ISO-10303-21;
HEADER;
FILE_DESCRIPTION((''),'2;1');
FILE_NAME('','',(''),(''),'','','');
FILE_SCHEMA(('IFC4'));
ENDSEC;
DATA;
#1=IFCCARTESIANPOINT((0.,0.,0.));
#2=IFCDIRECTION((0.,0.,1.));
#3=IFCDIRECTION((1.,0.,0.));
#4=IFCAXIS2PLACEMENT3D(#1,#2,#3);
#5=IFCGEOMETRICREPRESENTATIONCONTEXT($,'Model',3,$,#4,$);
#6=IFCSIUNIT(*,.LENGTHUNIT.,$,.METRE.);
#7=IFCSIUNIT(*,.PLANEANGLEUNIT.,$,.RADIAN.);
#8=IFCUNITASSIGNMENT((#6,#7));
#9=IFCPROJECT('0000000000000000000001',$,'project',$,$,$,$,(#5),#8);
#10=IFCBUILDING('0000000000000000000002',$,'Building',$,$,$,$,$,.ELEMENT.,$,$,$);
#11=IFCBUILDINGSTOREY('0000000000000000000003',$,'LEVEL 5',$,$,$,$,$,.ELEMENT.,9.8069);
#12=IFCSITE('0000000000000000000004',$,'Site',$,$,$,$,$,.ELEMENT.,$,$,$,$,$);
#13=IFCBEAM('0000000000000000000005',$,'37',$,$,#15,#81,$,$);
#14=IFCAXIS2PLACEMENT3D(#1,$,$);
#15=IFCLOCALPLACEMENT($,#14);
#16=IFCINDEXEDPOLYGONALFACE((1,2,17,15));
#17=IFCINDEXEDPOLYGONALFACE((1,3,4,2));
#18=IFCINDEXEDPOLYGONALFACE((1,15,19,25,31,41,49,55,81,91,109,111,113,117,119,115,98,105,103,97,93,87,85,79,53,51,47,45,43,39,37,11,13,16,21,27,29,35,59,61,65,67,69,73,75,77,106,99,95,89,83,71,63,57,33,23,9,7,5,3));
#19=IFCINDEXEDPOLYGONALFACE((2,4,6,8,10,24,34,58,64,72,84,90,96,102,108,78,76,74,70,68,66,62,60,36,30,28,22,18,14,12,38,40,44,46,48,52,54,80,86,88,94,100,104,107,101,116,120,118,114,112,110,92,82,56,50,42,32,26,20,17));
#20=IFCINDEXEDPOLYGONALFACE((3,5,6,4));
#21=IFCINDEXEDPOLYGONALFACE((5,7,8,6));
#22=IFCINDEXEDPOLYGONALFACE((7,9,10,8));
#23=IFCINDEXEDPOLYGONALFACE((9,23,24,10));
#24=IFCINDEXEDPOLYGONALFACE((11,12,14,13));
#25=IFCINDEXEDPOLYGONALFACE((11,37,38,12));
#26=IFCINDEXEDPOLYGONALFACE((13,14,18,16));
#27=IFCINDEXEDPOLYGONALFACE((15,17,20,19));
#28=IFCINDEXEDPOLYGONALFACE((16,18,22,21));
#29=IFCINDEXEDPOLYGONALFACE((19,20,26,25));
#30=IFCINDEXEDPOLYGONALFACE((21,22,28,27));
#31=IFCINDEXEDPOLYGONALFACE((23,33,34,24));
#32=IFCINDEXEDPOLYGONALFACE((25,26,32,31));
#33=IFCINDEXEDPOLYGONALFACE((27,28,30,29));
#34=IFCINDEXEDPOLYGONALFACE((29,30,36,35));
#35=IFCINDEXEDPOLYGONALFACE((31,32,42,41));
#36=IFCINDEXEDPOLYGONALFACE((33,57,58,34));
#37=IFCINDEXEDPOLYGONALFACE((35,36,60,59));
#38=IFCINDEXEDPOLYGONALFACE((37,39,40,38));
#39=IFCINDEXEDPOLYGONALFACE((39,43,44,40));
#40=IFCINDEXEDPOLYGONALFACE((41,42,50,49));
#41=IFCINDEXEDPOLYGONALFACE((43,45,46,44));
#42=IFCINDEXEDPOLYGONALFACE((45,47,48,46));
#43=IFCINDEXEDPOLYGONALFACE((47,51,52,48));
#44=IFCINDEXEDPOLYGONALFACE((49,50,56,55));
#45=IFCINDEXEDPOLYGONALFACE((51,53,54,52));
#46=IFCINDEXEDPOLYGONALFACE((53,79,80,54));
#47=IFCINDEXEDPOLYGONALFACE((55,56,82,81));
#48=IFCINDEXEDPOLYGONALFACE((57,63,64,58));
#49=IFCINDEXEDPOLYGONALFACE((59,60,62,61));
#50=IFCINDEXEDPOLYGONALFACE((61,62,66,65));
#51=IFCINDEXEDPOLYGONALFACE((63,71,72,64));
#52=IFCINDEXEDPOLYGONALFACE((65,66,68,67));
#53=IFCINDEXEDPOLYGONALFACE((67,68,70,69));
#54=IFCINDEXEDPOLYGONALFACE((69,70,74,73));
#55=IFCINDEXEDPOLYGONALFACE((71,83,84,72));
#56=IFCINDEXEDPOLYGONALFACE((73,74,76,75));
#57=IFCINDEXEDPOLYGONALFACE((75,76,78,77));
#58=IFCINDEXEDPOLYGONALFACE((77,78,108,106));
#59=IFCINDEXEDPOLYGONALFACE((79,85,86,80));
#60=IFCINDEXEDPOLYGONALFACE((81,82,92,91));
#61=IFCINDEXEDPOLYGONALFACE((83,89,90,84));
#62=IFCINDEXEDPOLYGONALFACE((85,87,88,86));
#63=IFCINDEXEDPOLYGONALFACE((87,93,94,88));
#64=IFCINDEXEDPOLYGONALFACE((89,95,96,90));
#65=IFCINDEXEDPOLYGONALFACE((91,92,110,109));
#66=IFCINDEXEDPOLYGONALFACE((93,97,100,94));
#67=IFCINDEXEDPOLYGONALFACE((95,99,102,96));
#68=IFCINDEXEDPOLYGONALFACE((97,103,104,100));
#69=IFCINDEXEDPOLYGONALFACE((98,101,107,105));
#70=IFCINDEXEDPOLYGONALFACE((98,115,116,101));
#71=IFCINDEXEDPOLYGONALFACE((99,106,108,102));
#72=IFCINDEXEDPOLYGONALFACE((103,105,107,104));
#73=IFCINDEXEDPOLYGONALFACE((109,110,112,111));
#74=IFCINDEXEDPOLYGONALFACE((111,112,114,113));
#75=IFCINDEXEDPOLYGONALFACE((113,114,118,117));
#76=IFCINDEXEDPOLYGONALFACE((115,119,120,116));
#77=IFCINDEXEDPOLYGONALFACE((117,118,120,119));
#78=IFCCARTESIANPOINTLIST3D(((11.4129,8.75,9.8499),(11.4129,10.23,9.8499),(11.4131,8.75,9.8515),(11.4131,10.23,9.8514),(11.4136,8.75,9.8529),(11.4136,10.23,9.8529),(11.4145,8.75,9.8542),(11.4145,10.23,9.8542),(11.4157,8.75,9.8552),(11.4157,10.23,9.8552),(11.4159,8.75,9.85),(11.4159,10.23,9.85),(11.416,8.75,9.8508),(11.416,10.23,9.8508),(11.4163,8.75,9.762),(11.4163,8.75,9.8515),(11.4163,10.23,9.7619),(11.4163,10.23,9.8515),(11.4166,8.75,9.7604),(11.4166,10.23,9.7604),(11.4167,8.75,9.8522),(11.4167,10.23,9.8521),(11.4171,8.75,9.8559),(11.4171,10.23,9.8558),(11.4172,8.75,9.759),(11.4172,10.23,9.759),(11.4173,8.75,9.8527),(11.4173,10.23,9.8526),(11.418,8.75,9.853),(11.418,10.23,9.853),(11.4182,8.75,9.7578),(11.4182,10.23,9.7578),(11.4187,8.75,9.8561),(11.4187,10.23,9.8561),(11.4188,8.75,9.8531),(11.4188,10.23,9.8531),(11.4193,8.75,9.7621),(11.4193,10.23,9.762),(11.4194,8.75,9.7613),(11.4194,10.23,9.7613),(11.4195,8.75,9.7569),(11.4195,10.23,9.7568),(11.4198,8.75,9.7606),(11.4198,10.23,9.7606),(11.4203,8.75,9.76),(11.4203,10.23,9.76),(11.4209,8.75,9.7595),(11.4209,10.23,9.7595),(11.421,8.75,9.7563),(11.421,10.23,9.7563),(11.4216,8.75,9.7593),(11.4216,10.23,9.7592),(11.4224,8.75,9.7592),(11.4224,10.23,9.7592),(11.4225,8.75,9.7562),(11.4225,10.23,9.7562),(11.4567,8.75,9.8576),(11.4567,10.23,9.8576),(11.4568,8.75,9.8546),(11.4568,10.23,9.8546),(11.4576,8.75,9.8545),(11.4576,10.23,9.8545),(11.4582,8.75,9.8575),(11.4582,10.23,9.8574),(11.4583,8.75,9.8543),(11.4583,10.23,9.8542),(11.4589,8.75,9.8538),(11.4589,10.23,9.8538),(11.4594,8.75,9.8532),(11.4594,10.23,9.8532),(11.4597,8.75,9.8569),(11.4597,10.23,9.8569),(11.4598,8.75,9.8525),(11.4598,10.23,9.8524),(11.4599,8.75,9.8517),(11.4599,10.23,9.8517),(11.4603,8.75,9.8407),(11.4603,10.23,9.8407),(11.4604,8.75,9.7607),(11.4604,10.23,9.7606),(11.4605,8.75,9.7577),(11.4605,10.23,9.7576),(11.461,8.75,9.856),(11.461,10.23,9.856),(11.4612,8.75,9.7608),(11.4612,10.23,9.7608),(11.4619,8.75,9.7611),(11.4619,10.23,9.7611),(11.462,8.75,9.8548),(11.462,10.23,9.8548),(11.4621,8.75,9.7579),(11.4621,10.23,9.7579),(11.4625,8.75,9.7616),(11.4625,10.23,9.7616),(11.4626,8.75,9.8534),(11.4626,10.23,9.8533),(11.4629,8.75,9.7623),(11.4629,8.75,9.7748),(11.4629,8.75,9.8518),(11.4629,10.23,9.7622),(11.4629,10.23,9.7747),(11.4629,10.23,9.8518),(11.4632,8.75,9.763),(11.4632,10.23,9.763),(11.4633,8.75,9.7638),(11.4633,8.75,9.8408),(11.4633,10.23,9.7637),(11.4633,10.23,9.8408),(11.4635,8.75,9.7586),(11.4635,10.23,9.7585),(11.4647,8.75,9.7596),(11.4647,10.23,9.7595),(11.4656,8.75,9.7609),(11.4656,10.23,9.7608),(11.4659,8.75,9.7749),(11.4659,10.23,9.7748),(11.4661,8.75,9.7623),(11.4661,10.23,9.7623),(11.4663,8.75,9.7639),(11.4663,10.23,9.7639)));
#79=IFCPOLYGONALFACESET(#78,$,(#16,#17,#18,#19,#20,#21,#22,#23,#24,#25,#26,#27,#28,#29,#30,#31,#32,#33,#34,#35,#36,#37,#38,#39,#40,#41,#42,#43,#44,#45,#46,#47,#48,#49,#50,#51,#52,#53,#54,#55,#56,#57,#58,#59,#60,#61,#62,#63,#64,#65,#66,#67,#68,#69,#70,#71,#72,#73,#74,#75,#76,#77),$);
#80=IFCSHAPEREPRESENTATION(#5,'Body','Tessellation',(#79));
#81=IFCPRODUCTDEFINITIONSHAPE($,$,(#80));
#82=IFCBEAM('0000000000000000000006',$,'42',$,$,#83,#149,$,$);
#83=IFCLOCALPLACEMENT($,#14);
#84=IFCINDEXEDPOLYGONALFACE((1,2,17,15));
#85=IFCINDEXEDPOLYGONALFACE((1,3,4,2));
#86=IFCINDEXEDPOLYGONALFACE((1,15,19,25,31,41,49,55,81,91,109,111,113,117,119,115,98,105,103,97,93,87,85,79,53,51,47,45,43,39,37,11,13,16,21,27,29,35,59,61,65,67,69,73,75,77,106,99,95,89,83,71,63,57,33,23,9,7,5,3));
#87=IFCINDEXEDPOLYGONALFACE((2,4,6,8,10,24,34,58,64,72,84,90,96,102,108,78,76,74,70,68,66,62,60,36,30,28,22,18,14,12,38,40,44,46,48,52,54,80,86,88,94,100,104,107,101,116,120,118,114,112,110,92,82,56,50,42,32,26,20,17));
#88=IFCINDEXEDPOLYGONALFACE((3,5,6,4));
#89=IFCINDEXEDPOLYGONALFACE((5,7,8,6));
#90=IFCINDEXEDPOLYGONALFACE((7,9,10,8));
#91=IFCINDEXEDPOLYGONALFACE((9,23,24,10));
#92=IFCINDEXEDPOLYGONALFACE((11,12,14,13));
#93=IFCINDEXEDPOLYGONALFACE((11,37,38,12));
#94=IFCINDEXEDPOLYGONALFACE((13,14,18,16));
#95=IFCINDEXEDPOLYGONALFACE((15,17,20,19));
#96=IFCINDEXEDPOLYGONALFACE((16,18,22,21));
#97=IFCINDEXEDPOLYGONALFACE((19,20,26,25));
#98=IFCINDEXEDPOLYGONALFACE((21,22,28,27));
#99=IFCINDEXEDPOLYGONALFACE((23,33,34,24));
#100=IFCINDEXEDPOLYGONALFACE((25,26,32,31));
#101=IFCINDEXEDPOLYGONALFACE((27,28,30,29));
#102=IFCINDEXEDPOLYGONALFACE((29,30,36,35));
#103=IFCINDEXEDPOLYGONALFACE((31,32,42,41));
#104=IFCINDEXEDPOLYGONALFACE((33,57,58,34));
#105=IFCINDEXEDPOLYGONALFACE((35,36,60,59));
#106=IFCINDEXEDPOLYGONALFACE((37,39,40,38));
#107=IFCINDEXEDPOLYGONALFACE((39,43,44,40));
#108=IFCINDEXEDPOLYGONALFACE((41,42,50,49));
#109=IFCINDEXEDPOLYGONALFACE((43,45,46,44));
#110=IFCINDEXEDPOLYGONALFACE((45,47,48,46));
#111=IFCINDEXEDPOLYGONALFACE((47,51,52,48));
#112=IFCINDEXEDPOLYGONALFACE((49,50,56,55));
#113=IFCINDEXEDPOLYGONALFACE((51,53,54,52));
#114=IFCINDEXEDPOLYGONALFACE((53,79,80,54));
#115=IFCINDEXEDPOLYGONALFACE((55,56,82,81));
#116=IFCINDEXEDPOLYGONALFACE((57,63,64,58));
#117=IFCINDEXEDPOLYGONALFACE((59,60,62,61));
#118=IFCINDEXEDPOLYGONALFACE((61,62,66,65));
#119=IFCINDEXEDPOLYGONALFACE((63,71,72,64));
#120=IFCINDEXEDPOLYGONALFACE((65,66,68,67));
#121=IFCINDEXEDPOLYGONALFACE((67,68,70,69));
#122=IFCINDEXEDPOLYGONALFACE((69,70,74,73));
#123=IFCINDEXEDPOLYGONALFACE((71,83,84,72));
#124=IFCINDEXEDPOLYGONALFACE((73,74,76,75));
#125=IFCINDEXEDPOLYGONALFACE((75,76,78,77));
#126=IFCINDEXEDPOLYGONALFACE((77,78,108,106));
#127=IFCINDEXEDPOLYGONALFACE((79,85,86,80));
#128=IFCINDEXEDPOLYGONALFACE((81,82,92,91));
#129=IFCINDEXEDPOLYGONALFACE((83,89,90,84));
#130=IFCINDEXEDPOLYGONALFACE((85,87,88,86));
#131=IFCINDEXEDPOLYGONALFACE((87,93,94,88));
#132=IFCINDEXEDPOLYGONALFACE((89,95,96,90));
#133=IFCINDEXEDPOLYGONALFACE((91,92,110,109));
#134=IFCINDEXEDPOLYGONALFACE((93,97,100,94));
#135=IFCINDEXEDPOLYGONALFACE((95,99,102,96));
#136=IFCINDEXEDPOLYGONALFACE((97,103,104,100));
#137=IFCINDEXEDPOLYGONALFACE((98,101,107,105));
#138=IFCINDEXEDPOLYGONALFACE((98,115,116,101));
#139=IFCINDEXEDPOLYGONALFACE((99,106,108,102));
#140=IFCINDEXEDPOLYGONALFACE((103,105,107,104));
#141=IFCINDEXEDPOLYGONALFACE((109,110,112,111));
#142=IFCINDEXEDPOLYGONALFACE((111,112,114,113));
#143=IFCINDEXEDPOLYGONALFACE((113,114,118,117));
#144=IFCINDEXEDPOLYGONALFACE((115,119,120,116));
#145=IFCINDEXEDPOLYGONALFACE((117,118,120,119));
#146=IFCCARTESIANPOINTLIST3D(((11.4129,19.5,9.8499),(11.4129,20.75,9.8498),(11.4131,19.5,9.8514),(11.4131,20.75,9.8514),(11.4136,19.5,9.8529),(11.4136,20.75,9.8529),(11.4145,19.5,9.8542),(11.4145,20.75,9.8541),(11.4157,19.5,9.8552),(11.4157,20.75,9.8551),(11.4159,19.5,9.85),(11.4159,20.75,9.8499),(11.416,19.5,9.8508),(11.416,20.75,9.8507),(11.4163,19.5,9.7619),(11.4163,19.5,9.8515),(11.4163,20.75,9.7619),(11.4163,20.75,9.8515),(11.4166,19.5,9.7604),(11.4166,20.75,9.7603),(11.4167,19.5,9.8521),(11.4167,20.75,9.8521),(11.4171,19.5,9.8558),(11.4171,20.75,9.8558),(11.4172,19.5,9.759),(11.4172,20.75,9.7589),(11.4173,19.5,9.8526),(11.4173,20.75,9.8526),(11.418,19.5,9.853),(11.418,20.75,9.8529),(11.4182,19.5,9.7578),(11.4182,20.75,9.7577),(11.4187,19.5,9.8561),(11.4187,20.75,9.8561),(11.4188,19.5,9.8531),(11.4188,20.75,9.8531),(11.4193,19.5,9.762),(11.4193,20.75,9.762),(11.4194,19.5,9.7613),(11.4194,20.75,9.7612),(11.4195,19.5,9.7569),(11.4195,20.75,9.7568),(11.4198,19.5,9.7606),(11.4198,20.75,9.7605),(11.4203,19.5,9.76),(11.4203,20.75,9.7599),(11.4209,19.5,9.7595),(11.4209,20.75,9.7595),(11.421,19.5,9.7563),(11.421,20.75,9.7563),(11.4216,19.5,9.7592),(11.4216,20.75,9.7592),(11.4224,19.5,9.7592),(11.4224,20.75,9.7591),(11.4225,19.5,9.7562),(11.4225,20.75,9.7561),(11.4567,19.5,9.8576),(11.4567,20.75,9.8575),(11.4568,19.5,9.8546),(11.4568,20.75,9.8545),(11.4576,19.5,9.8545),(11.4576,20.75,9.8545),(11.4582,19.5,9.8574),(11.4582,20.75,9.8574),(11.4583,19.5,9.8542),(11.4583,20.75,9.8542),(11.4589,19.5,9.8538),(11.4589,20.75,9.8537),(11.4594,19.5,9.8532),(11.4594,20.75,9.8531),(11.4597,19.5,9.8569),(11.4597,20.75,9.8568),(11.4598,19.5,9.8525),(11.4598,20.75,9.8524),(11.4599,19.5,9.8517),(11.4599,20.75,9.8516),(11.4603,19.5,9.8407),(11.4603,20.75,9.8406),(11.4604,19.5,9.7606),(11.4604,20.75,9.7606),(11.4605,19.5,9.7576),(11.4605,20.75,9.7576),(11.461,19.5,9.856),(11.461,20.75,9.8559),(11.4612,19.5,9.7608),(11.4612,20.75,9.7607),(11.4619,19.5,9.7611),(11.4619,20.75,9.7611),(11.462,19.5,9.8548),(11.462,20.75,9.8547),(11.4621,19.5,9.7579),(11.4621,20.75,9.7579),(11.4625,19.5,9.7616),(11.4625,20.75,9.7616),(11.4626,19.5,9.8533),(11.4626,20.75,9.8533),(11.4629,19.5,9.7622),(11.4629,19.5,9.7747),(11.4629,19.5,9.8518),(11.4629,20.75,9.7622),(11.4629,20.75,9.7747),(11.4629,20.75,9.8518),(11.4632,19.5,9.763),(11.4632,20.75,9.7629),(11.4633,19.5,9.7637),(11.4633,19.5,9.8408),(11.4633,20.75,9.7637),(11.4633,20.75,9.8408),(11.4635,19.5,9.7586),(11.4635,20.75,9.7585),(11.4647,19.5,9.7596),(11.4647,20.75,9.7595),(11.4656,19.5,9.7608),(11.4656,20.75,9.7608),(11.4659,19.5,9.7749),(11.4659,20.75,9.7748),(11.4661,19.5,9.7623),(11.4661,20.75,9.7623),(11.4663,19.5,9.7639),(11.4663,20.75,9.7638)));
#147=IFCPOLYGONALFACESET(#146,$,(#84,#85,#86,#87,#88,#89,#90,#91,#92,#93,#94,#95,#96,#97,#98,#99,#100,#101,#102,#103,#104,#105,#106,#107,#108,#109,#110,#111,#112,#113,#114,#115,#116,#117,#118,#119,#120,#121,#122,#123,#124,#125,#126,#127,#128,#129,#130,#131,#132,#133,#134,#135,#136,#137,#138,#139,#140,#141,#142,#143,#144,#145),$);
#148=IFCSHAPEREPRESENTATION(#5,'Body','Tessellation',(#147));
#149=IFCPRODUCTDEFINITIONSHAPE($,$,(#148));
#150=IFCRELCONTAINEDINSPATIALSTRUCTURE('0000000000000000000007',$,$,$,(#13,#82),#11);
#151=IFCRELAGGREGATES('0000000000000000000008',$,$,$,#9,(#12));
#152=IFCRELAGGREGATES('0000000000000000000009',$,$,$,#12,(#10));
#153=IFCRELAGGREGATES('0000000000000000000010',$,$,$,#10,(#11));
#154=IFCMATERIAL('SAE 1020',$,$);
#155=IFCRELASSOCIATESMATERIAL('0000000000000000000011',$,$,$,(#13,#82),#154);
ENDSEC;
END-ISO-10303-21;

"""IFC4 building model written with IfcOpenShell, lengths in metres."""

from ifc_helpers import new_model, si_unit, frame, origin_with_axes, origin_2d_with_axis, place, context, project, spatial, c_section, extrude, material, material_profile, profile_set, profile_usage, element, save


model = new_model("IFC4")

# Units and contexts
model_context = context("Model", 3, world=origin_with_axes())
ifc_project = project(units=[si_unit("LENGTHUNIT", "METRE"), si_unit("PLANEANGLEUNIT", "RADIAN")], contexts=[model_context])

# Site, building, storey
site = spatial("IfcSite", under=ifc_project, Name="Site", CompositionType="ELEMENT")
building = spatial("IfcBuilding", under=site, Name="Building", CompositionType="ELEMENT")
storey = spatial("IfcBuildingStorey", under=building, Name="LEVEL 5", CompositionType="ELEMENT", Elevation=9.8069)

# Beams
ifc_material = material(Name="SAE 1020")
ifc_material_profile_1 = material_profile(ifc_material, c_section(Depth=0.1, Width=0.05, WallThickness=0.003, Girth=0.017, InternalFilletRadius=0.003, at=origin_2d_with_axis()))
ifc_profile_set_1 = profile_set([ifc_material_profile_1])
ifc_profile_usage_1 = profile_usage(ifc_profile_set_1, cardinal=10)
beam_1_placement = place(None, frame((11.4396, 8.75, 9.8069), z_axis=(0.0, 1.0, -0.00003), x_axis=(0.999256, 0.000001, 0.038562)))
element("IfcBeam", 1, at=beam_1_placement, inside=storey, material=ifc_profile_usage_1, Name="37", context=model_context, shape_type="SweptSolid", body=[
    extrude(c_section(Depth=0.1, Width=0.05, WallThickness=0.003, Girth=0.017, InternalFilletRadius=0.003, at=origin_2d_with_axis()), origin_with_axes(), (0.0, 0.0, 1.0), 1.48),
])
ifc_material_profile_2 = material_profile(ifc_material, c_section(Depth=0.1, Width=0.05, WallThickness=0.003, Girth=0.017, InternalFilletRadius=0.003, at=origin_2d_with_axis()))
ifc_profile_set_2 = profile_set([ifc_material_profile_2])
ifc_profile_usage_2 = profile_usage(ifc_profile_set_2, cardinal=10)
beam_2_placement = place(None, frame((11.4396, 19.5, 9.8069), z_axis=(0.0, 1.0, -0.00003), x_axis=(0.999256, 0.000001, 0.038562)))
element("IfcBeam", 2, at=beam_2_placement, inside=storey, material=ifc_profile_usage_2, Name="42", context=model_context, shape_type="SweptSolid", body=[
    extrude(c_section(Depth=0.1, Width=0.05, WallThickness=0.003, Girth=0.017, InternalFilletRadius=0.003, at=origin_2d_with_axis()), origin_with_axes(), (0.0, 0.0, 1.0), 1.25),
])

save(model, "model.ifc")
